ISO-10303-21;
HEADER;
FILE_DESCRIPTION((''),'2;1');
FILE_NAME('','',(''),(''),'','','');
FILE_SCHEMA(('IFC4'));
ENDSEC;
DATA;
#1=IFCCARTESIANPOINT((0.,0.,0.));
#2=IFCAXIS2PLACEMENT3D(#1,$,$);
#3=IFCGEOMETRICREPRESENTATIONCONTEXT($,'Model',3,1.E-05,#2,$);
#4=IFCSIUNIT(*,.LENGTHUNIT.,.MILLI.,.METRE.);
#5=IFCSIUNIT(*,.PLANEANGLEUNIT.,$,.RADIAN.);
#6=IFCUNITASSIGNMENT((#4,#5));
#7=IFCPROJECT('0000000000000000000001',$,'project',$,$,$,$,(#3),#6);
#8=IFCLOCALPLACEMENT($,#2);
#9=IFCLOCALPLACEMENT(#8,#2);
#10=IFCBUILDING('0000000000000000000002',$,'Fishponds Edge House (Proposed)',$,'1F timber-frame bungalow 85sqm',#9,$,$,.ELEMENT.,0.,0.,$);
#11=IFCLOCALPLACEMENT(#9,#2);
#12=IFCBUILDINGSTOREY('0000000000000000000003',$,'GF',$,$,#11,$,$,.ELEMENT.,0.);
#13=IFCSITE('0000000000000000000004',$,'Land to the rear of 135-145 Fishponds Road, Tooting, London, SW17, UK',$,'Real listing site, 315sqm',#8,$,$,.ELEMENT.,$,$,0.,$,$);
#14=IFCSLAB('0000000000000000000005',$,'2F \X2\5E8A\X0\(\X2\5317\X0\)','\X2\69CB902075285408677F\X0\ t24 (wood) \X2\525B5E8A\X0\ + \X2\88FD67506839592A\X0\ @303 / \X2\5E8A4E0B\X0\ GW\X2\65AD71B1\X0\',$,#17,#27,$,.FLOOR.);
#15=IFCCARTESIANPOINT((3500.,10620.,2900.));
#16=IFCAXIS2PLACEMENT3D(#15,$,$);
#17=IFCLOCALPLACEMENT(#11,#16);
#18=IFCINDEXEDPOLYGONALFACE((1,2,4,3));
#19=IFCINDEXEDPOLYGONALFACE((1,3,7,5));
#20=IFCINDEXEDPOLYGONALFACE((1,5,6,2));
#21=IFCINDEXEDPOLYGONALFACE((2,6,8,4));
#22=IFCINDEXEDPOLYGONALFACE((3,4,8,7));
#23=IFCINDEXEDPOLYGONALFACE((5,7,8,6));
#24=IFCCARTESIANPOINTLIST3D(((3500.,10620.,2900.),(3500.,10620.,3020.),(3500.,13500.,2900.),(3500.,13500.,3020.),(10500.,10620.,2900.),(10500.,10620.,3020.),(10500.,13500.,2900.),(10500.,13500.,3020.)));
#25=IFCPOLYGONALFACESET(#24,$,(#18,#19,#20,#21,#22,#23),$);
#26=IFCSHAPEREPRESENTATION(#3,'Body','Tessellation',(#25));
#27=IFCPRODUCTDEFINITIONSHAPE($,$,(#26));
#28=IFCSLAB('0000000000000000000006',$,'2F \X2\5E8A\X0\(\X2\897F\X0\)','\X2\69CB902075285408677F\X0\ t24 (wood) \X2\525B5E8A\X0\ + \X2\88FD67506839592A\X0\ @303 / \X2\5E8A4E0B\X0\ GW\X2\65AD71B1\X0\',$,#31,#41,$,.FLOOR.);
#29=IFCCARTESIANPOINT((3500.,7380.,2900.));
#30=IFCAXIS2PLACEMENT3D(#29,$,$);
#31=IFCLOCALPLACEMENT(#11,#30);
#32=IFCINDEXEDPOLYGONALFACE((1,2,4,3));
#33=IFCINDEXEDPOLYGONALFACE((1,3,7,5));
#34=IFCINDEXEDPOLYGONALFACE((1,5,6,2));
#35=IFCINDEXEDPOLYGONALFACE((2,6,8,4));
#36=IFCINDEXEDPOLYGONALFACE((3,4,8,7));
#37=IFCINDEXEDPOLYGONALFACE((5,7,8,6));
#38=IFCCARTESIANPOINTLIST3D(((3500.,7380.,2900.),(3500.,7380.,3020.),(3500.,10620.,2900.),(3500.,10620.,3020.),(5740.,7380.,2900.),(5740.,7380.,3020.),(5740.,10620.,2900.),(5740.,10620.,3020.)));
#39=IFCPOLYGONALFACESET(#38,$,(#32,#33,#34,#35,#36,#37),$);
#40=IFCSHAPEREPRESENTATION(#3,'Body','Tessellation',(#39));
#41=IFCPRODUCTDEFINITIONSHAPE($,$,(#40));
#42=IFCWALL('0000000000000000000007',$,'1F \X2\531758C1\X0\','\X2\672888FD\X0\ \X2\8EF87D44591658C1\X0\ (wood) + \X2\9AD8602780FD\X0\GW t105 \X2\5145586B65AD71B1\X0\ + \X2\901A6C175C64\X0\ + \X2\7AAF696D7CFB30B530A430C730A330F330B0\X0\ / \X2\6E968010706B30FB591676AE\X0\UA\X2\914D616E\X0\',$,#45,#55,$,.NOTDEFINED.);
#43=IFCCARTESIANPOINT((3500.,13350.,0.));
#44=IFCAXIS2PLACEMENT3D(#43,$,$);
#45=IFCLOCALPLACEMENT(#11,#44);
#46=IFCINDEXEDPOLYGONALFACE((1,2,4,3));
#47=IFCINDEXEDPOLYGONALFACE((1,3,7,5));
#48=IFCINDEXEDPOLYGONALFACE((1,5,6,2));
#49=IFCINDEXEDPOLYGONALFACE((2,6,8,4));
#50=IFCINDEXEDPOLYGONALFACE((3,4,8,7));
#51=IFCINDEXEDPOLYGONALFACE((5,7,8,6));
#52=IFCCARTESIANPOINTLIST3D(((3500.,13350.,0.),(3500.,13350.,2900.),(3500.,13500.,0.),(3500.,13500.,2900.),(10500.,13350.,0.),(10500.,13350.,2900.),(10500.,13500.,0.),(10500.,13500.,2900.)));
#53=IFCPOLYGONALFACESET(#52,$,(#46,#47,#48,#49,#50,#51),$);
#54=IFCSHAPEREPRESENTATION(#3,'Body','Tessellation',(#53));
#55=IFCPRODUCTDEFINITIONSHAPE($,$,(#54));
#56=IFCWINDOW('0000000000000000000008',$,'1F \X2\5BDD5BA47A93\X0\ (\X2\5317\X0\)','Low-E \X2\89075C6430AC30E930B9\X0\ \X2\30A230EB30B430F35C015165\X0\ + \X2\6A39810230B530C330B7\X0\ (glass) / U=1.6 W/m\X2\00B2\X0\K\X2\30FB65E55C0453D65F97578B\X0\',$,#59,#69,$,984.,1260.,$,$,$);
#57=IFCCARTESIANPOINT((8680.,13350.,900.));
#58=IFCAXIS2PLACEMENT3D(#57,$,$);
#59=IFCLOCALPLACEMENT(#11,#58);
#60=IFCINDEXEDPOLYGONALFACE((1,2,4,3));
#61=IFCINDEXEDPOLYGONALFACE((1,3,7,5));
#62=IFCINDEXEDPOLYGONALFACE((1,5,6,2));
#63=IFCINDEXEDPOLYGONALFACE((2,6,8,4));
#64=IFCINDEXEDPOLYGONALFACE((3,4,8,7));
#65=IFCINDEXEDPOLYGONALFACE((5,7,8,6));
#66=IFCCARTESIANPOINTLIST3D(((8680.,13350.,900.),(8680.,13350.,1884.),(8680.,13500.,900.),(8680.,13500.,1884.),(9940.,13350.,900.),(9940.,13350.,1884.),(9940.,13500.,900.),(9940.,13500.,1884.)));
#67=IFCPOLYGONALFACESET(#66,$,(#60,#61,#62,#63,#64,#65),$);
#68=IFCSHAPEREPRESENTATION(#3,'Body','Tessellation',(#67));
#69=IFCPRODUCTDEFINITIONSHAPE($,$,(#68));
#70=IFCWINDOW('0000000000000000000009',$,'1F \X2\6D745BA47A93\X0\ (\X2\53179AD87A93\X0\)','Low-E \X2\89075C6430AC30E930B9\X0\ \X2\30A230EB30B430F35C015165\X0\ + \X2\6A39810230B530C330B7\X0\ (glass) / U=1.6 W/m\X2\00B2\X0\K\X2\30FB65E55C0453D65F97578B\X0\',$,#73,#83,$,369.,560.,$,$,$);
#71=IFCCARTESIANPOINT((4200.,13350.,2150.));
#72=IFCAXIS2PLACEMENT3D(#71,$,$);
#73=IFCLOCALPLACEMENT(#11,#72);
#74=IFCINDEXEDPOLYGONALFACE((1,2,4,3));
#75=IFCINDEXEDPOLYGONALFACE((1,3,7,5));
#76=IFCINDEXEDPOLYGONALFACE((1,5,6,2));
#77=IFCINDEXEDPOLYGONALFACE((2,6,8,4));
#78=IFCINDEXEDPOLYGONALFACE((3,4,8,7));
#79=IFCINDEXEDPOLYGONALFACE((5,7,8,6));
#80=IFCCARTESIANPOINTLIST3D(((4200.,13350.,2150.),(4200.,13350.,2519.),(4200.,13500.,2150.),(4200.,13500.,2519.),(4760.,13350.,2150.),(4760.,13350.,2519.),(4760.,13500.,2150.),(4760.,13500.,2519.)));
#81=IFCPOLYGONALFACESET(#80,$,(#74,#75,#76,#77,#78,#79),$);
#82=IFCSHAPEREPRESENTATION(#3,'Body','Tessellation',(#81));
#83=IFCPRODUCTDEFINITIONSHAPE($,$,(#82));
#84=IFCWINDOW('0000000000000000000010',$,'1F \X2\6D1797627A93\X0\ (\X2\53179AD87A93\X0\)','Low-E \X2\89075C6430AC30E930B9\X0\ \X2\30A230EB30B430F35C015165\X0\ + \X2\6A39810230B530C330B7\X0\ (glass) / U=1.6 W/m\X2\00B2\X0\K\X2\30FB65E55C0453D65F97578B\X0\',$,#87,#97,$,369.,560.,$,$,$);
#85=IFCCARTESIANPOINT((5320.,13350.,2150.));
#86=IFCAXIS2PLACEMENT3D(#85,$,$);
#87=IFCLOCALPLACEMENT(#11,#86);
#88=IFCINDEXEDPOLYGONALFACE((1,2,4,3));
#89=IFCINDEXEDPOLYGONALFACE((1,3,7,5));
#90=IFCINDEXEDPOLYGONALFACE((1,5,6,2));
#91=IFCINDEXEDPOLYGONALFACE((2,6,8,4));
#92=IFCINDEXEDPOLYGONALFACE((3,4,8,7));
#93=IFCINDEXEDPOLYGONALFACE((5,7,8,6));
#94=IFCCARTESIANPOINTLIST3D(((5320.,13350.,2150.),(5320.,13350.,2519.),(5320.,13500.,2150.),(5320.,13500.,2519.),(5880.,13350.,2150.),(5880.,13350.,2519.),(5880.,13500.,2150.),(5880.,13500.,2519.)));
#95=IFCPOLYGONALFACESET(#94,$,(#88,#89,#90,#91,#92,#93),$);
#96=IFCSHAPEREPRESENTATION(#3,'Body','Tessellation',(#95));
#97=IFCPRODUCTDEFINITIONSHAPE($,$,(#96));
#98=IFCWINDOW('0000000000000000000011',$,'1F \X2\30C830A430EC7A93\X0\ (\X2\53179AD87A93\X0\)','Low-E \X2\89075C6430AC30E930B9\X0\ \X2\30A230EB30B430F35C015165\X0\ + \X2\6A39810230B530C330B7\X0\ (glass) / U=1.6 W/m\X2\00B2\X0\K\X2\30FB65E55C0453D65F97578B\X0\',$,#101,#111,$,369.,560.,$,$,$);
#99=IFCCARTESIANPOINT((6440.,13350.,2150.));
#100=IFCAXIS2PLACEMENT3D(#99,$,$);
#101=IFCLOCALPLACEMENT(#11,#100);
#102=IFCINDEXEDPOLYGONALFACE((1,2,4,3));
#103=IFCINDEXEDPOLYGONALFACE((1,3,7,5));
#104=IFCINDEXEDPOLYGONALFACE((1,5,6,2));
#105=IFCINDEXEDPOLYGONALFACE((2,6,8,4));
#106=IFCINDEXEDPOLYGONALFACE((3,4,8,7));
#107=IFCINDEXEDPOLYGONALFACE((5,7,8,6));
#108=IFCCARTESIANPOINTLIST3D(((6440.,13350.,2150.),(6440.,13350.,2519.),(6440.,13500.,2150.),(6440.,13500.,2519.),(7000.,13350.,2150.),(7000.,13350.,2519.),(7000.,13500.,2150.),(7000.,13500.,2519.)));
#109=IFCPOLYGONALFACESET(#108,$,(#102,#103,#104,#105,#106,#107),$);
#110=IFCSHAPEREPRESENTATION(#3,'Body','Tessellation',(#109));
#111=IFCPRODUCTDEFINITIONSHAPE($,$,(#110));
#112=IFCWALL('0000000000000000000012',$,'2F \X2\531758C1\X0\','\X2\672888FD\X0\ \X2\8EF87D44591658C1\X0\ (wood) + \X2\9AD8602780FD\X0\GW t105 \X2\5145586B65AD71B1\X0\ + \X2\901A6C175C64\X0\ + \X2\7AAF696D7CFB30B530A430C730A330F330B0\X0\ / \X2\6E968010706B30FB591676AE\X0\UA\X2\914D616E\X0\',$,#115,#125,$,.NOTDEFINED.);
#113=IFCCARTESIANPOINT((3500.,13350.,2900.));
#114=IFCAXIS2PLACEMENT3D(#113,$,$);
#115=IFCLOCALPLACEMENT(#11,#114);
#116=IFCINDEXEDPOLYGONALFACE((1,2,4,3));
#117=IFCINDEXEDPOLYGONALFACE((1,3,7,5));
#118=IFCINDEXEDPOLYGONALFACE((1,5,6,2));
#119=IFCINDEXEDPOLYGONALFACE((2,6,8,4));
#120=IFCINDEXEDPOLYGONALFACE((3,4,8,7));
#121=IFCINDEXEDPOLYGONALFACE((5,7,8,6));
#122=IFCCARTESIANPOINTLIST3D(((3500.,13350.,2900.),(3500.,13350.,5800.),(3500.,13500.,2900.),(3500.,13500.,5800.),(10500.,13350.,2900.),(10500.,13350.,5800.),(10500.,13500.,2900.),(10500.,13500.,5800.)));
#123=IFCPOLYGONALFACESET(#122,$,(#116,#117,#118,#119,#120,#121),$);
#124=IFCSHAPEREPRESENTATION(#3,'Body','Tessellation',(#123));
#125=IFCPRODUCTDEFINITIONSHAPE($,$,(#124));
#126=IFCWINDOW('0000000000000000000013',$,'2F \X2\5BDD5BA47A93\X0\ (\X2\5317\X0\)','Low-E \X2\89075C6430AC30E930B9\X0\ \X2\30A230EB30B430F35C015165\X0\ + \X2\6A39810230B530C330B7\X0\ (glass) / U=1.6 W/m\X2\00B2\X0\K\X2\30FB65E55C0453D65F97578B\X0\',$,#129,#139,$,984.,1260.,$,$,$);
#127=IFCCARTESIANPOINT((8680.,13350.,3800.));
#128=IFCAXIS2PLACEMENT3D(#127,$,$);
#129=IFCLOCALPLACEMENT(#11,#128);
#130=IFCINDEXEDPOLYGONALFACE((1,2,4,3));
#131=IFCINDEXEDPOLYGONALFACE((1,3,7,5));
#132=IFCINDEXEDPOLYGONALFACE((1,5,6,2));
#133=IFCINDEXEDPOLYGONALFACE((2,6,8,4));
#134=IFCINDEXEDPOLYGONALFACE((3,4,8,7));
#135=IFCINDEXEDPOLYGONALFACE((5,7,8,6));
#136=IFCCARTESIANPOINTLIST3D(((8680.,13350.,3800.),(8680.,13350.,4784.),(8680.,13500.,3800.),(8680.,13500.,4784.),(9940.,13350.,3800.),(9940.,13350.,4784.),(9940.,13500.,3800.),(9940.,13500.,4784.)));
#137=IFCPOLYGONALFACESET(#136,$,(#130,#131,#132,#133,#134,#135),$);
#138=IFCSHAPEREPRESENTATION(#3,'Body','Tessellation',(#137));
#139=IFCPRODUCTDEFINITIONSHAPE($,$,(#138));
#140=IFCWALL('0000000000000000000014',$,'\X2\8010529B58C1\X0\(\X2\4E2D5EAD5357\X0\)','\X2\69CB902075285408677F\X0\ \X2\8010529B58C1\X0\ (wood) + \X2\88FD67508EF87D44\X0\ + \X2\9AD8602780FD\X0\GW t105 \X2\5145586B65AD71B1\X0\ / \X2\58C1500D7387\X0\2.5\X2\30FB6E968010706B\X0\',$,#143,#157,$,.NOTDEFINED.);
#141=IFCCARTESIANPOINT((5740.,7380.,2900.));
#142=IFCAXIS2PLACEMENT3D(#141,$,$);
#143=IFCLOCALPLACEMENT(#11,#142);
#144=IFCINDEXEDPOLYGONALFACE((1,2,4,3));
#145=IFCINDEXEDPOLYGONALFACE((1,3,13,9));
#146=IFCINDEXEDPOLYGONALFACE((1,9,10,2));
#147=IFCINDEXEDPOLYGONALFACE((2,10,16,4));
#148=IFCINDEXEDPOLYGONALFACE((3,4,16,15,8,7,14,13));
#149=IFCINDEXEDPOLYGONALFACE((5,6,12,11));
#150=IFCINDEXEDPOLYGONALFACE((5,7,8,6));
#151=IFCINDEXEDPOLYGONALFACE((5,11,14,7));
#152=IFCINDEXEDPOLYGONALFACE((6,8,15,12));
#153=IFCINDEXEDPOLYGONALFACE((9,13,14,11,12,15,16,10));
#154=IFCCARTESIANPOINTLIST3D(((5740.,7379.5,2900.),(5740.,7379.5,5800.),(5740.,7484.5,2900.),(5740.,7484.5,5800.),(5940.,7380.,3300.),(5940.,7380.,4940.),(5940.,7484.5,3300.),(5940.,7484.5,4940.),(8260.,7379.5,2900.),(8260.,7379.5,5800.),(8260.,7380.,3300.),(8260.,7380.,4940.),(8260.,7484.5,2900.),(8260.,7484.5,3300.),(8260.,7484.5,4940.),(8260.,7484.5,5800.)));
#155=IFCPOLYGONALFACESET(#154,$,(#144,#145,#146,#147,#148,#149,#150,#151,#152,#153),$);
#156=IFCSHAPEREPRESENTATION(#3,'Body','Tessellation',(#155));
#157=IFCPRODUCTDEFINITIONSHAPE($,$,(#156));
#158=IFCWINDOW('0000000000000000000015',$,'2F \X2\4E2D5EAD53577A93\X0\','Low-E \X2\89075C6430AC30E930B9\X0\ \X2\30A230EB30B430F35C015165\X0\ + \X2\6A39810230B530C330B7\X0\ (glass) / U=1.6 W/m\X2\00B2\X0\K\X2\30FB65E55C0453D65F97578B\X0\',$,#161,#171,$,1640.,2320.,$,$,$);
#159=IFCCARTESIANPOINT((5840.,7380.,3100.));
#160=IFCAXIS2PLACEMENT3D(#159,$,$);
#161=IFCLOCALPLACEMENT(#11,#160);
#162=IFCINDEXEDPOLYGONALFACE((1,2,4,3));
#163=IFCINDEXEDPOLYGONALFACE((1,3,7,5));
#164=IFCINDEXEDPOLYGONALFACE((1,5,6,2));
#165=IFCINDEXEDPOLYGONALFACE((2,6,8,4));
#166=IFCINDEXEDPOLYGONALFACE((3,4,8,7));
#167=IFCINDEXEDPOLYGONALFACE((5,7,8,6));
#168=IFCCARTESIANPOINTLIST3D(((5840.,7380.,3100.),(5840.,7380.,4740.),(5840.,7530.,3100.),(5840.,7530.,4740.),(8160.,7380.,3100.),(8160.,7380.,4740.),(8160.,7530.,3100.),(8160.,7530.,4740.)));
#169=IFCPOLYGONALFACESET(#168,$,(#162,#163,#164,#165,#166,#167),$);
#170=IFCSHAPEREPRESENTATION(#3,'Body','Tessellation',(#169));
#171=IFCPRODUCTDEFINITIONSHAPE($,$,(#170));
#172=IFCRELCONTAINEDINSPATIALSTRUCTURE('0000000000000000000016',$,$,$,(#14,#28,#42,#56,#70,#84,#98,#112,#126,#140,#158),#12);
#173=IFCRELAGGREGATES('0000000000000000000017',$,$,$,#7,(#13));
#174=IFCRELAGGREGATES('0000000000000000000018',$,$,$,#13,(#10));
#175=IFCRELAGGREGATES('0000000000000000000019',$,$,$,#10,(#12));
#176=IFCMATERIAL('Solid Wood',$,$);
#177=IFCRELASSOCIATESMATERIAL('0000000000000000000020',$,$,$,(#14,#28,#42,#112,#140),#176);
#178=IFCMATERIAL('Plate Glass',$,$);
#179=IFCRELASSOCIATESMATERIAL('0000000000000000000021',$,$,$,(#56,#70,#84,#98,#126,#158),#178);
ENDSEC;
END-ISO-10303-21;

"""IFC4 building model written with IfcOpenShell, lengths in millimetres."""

from ifc_helpers import new_model, si_unit, frame, frame_2d, origin, place, context, project, spatial, rectangle, extrude, material, element, fill, save


model = new_model("IFC4")

# Units and contexts
model_context = context("Model", 3, precision=1e-05, world=origin())
ifc_project = project(units=[si_unit("LENGTHUNIT", "METRE", prefix="MILLI"), si_unit("PLANEANGLEUNIT", "RADIAN")], contexts=[model_context])

# Site, building, storey
site_placement = place(None, origin())
site = spatial("IfcSite", under=ifc_project, at=site_placement, Name="Land to the rear of 135-145 Fishponds Road, Tooting, London, SW17, UK", ObjectType="Real listing site, 315sqm", CompositionType="ELEMENT", RefElevation=0.0)
building_placement = place(site_placement, origin())
building = spatial("IfcBuilding", under=site, at=building_placement, Name="Fishponds Edge House (Proposed)", ObjectType="1F timber-frame bungalow 85sqm", CompositionType="ELEMENT", ElevationOfRefHeight=0.0, ElevationOfTerrain=0.0)
storey_placement = place(building_placement, origin())
storey = spatial("IfcBuildingStorey", under=building, at=storey_placement, Name="GF", CompositionType="ELEMENT", Elevation=0.0)

# Slabs
ifc_material_1 = material(Name="Solid Wood")
slab_1_placement = place(storey_placement, frame((3500.0, 10620.0, 2900.0)))
element("IfcSlab", 1, at=slab_1_placement, inside=storey, material=ifc_material_1, Name="2F 床(北)", Description="構造用合板 t24 (wood) 剛床 + 製材根太 @303 / 床下 GW断熱", PredefinedType="FLOOR", context=model_context, shape_type="SweptSolid", body=[
    extrude(rectangle(XDim=7000.0, YDim=2880.0, at=frame_2d((3500.0, 1440.0))), frame((3500.0, 10620.0, 2900.0)), (0.0, 0.0, 1.0), 120.0),
])
slab_2_placement = place(storey_placement, frame((3500.0, 7380.0, 2900.0)))
element("IfcSlab", 2, at=slab_2_placement, inside=storey, material=ifc_material_1, Name="2F 床(西)", Description="構造用合板 t24 (wood) 剛床 + 製材根太 @303 / 床下 GW断熱", PredefinedType="FLOOR", context=model_context, shape_type="SweptSolid", body=[
    extrude(rectangle(XDim=2240.0, YDim=3240.0, at=frame_2d((1120.0, 1620.0))), frame((3500.0, 7380.0, 2900.0)), (0.0, 0.0, 1.0), 120.0),
])

# Wall, openings, windows
wall_1_placement = place(storey_placement, frame((3500.0, 13350.0, 0.0)))
wall_1 = element("IfcWall", 3, at=wall_1_placement, inside=storey, material=ifc_material_1, Name="1F 北壁", Description="木製 軸組外壁 (wood) + 高性能GW t105 充填断熱 + 通気層 + 窯業系サイディング / 準耐火・外皮UA配慮", PredefinedType="NOTDEFINED", context=model_context, shape_type="SweptSolid", body=[
    extrude(rectangle(XDim=7000.0, YDim=150.0, at=frame_2d((3500.0, 75.0))), frame((3500.0, 13350.0, 0.0)), (0.0, 0.0, 1.0), 2900.0),
])
opening_1_placement = place(storey_placement, frame((8680.0, 13350.0, 900.0)))
opening_1 = element("IfcOpeningElement", 4, at=opening_1_placement, cuts=wall_1, PredefinedType="NOTDEFINED", context=model_context, shape_type="SweptSolid", body=[
    extrude(rectangle(XDim=1260.0, YDim=150.0, at=frame_2d((630.0, 75.0))), frame((8680.0, 13350.0, 900.0)), (0.0, 0.0, 1.0), 984.0),
])
opening_2_placement = place(storey_placement, frame((4200.0, 13350.0, 2150.0)))
opening_2 = element("IfcOpeningElement", 5, at=opening_2_placement, cuts=wall_1, PredefinedType="NOTDEFINED", context=model_context, shape_type="SweptSolid", body=[
    extrude(rectangle(XDim=560.0, YDim=150.0, at=frame_2d((280.0, 75.0))), frame((4200.0, 13350.0, 2150.0)), (0.0, 0.0, 1.0), 369.0),
])
opening_3_placement = place(storey_placement, frame((5320.0, 13350.0, 2150.0)))
opening_3 = element("IfcOpeningElement", 6, at=opening_3_placement, cuts=wall_1, PredefinedType="NOTDEFINED", context=model_context, shape_type="SweptSolid", body=[
    extrude(rectangle(XDim=560.0, YDim=150.0, at=frame_2d((280.0, 75.0))), frame((5320.0, 13350.0, 2150.0)), (0.0, 0.0, 1.0), 369.0),
])
opening_4_placement = place(storey_placement, frame((6440.0, 13350.0, 2150.0)))
opening_4 = element("IfcOpeningElement", 7, at=opening_4_placement, cuts=wall_1, PredefinedType="NOTDEFINED", context=model_context, shape_type="SweptSolid", body=[
    extrude(rectangle(XDim=560.0, YDim=150.0, at=frame_2d((280.0, 75.0))), frame((6440.0, 13350.0, 2150.0)), (0.0, 0.0, 1.0), 369.0),
])
ifc_material_2 = material(Name="Plate Glass")
window_1_placement = place(storey_placement, frame((8680.0, 13350.0, 900.0)))
window_1 = element("IfcWindow", 8, at=window_1_placement, inside=storey, material=ifc_material_2, Name="1F 寝室窓 (北)", Description="Low-E 複層ガラス アルゴン封入 + 樹脂サッシ (glass) / U=1.6 W/m²K・日射取得型", OverallHeight=984.0, OverallWidth=1260.0, context=model_context, shape_type="SweptSolid", body=[
    extrude(rectangle(XDim=1260.0, YDim=150.0, at=frame_2d((630.0, 75.0))), frame((8680.0, 13350.0, 900.0)), (0.0, 0.0, 1.0), 984.0),
])
fill(opening_1, window_1)
window_2_placement = place(storey_placement, frame((4200.0, 13350.0, 2150.0)))
window_2 = element("IfcWindow", 9, at=window_2_placement, inside=storey, material=ifc_material_2, Name="1F 浴室窓 (北高窓)", Description="Low-E 複層ガラス アルゴン封入 + 樹脂サッシ (glass) / U=1.6 W/m²K・日射取得型", OverallHeight=369.0, OverallWidth=560.0, context=model_context, shape_type="SweptSolid", body=[
    extrude(rectangle(XDim=560.0, YDim=150.0, at=frame_2d((280.0, 75.0))), frame((4200.0, 13350.0, 2150.0)), (0.0, 0.0, 1.0), 369.0),
])
fill(opening_2, window_2)
window_3_placement = place(storey_placement, frame((5320.0, 13350.0, 2150.0)))
window_3 = element("IfcWindow", 10, at=window_3_placement, inside=storey, material=ifc_material_2, Name="1F 洗面窓 (北高窓)", Description="Low-E 複層ガラス アルゴン封入 + 樹脂サッシ (glass) / U=1.6 W/m²K・日射取得型", OverallHeight=369.0, OverallWidth=560.0, context=model_context, shape_type="SweptSolid", body=[
    extrude(rectangle(XDim=560.0, YDim=150.0, at=frame_2d((280.0, 75.0))), frame((5320.0, 13350.0, 2150.0)), (0.0, 0.0, 1.0), 369.0),
])
fill(opening_3, window_3)
window_4_placement = place(storey_placement, frame((6440.0, 13350.0, 2150.0)))
window_4 = element("IfcWindow", 11, at=window_4_placement, inside=storey, material=ifc_material_2, Name="1F トイレ窓 (北高窓)", Description="Low-E 複層ガラス アルゴン封入 + 樹脂サッシ (glass) / U=1.6 W/m²K・日射取得型", OverallHeight=369.0, OverallWidth=560.0, context=model_context, shape_type="SweptSolid", body=[
    extrude(rectangle(XDim=560.0, YDim=150.0, at=frame_2d((280.0, 75.0))), frame((6440.0, 13350.0, 2150.0)), (0.0, 0.0, 1.0), 369.0),
])
fill(opening_4, window_4)

# Walls, openings, windows
wall_2_placement = place(storey_placement, frame((3500.0, 13350.0, 2900.0)))
wall_2 = element("IfcWall", 12, at=wall_2_placement, inside=storey, material=ifc_material_1, Name="2F 北壁", Description="木製 軸組外壁 (wood) + 高性能GW t105 充填断熱 + 通気層 + 窯業系サイディング / 準耐火・外皮UA配慮", PredefinedType="NOTDEFINED", context=model_context, shape_type="SweptSolid", body=[
    extrude(rectangle(XDim=7000.0, YDim=150.0, at=frame_2d((3500.0, 75.0))), frame((3500.0, 13350.0, 2900.0)), (0.0, 0.0, 1.0), 2900.0),
])
opening_5_placement = place(storey_placement, frame((8680.0, 13350.0, 3800.0)))
opening_5 = element("IfcOpeningElement", 13, at=opening_5_placement, cuts=wall_2, PredefinedType="NOTDEFINED", context=model_context, shape_type="SweptSolid", body=[
    extrude(rectangle(XDim=1260.0, YDim=150.0, at=frame_2d((630.0, 75.0))), frame((8680.0, 13350.0, 3800.0)), (0.0, 0.0, 1.0), 984.0),
])
window_5_placement = place(storey_placement, frame((8680.0, 13350.0, 3800.0)))
window_5 = element("IfcWindow", 14, at=window_5_placement, inside=storey, material=ifc_material_2, Name="2F 寝室窓 (北)", Description="Low-E 複層ガラス アルゴン封入 + 樹脂サッシ (glass) / U=1.6 W/m²K・日射取得型", OverallHeight=984.0, OverallWidth=1260.0, context=model_context, shape_type="SweptSolid", body=[
    extrude(rectangle(XDim=1260.0, YDim=150.0, at=frame_2d((630.0, 75.0))), frame((8680.0, 13350.0, 3800.0)), (0.0, 0.0, 1.0), 984.0),
])
fill(opening_5, window_5)
wall_3_placement = place(storey_placement, frame((5740.0, 7380.0, 2900.0)))
wall_3 = element("IfcWall", 15, at=wall_3_placement, inside=storey, material=ifc_material_1, Name="耐力壁(中庭南)", Description="構造用合板 耐力壁 (wood) + 製材軸組 + 高性能GW t105 充填断熱 / 壁倍率2.5・準耐火", PredefinedType="NOTDEFINED", context=model_context, shape_type="SweptSolid", body=[
    extrude(rectangle(XDim=2520.0, YDim=105.0, at=frame_2d((1260.0, 52.0))), frame((5740.0, 7380.0, 2900.0)), (0.0, 0.0, 1.0), 2900.0),
])
opening_6_placement = place(storey_placement, frame((5840.0, 7380.0, 3100.0)))
opening_6 = element("IfcOpeningElement", 16, at=opening_6_placement, cuts=wall_3, PredefinedType="NOTDEFINED", context=model_context, shape_type="SweptSolid", body=[
    extrude(rectangle(XDim=2320.0, YDim=150.0, at=frame_2d((1160.0, 75.0))), frame((5840.0, 7380.0, 3100.0)), (0.0, 0.0, 1.0), 1640.0),
])
window_6_placement = place(storey_placement, frame((5840.0, 7380.0, 3100.0)))
window_6 = element("IfcWindow", 17, at=window_6_placement, inside=storey, material=ifc_material_2, Name="2F 中庭南窓", Description="Low-E 複層ガラス アルゴン封入 + 樹脂サッシ (glass) / U=1.6 W/m²K・日射取得型", OverallHeight=1640.0, OverallWidth=2320.0, context=model_context, shape_type="SweptSolid", body=[
    extrude(rectangle(XDim=2320.0, YDim=150.0, at=frame_2d((1160.0, 75.0))), frame((5840.0, 7380.0, 3100.0)), (0.0, 0.0, 1.0), 1640.0),
])
fill(opening_6, window_6)

save(model, "model.ifc")
